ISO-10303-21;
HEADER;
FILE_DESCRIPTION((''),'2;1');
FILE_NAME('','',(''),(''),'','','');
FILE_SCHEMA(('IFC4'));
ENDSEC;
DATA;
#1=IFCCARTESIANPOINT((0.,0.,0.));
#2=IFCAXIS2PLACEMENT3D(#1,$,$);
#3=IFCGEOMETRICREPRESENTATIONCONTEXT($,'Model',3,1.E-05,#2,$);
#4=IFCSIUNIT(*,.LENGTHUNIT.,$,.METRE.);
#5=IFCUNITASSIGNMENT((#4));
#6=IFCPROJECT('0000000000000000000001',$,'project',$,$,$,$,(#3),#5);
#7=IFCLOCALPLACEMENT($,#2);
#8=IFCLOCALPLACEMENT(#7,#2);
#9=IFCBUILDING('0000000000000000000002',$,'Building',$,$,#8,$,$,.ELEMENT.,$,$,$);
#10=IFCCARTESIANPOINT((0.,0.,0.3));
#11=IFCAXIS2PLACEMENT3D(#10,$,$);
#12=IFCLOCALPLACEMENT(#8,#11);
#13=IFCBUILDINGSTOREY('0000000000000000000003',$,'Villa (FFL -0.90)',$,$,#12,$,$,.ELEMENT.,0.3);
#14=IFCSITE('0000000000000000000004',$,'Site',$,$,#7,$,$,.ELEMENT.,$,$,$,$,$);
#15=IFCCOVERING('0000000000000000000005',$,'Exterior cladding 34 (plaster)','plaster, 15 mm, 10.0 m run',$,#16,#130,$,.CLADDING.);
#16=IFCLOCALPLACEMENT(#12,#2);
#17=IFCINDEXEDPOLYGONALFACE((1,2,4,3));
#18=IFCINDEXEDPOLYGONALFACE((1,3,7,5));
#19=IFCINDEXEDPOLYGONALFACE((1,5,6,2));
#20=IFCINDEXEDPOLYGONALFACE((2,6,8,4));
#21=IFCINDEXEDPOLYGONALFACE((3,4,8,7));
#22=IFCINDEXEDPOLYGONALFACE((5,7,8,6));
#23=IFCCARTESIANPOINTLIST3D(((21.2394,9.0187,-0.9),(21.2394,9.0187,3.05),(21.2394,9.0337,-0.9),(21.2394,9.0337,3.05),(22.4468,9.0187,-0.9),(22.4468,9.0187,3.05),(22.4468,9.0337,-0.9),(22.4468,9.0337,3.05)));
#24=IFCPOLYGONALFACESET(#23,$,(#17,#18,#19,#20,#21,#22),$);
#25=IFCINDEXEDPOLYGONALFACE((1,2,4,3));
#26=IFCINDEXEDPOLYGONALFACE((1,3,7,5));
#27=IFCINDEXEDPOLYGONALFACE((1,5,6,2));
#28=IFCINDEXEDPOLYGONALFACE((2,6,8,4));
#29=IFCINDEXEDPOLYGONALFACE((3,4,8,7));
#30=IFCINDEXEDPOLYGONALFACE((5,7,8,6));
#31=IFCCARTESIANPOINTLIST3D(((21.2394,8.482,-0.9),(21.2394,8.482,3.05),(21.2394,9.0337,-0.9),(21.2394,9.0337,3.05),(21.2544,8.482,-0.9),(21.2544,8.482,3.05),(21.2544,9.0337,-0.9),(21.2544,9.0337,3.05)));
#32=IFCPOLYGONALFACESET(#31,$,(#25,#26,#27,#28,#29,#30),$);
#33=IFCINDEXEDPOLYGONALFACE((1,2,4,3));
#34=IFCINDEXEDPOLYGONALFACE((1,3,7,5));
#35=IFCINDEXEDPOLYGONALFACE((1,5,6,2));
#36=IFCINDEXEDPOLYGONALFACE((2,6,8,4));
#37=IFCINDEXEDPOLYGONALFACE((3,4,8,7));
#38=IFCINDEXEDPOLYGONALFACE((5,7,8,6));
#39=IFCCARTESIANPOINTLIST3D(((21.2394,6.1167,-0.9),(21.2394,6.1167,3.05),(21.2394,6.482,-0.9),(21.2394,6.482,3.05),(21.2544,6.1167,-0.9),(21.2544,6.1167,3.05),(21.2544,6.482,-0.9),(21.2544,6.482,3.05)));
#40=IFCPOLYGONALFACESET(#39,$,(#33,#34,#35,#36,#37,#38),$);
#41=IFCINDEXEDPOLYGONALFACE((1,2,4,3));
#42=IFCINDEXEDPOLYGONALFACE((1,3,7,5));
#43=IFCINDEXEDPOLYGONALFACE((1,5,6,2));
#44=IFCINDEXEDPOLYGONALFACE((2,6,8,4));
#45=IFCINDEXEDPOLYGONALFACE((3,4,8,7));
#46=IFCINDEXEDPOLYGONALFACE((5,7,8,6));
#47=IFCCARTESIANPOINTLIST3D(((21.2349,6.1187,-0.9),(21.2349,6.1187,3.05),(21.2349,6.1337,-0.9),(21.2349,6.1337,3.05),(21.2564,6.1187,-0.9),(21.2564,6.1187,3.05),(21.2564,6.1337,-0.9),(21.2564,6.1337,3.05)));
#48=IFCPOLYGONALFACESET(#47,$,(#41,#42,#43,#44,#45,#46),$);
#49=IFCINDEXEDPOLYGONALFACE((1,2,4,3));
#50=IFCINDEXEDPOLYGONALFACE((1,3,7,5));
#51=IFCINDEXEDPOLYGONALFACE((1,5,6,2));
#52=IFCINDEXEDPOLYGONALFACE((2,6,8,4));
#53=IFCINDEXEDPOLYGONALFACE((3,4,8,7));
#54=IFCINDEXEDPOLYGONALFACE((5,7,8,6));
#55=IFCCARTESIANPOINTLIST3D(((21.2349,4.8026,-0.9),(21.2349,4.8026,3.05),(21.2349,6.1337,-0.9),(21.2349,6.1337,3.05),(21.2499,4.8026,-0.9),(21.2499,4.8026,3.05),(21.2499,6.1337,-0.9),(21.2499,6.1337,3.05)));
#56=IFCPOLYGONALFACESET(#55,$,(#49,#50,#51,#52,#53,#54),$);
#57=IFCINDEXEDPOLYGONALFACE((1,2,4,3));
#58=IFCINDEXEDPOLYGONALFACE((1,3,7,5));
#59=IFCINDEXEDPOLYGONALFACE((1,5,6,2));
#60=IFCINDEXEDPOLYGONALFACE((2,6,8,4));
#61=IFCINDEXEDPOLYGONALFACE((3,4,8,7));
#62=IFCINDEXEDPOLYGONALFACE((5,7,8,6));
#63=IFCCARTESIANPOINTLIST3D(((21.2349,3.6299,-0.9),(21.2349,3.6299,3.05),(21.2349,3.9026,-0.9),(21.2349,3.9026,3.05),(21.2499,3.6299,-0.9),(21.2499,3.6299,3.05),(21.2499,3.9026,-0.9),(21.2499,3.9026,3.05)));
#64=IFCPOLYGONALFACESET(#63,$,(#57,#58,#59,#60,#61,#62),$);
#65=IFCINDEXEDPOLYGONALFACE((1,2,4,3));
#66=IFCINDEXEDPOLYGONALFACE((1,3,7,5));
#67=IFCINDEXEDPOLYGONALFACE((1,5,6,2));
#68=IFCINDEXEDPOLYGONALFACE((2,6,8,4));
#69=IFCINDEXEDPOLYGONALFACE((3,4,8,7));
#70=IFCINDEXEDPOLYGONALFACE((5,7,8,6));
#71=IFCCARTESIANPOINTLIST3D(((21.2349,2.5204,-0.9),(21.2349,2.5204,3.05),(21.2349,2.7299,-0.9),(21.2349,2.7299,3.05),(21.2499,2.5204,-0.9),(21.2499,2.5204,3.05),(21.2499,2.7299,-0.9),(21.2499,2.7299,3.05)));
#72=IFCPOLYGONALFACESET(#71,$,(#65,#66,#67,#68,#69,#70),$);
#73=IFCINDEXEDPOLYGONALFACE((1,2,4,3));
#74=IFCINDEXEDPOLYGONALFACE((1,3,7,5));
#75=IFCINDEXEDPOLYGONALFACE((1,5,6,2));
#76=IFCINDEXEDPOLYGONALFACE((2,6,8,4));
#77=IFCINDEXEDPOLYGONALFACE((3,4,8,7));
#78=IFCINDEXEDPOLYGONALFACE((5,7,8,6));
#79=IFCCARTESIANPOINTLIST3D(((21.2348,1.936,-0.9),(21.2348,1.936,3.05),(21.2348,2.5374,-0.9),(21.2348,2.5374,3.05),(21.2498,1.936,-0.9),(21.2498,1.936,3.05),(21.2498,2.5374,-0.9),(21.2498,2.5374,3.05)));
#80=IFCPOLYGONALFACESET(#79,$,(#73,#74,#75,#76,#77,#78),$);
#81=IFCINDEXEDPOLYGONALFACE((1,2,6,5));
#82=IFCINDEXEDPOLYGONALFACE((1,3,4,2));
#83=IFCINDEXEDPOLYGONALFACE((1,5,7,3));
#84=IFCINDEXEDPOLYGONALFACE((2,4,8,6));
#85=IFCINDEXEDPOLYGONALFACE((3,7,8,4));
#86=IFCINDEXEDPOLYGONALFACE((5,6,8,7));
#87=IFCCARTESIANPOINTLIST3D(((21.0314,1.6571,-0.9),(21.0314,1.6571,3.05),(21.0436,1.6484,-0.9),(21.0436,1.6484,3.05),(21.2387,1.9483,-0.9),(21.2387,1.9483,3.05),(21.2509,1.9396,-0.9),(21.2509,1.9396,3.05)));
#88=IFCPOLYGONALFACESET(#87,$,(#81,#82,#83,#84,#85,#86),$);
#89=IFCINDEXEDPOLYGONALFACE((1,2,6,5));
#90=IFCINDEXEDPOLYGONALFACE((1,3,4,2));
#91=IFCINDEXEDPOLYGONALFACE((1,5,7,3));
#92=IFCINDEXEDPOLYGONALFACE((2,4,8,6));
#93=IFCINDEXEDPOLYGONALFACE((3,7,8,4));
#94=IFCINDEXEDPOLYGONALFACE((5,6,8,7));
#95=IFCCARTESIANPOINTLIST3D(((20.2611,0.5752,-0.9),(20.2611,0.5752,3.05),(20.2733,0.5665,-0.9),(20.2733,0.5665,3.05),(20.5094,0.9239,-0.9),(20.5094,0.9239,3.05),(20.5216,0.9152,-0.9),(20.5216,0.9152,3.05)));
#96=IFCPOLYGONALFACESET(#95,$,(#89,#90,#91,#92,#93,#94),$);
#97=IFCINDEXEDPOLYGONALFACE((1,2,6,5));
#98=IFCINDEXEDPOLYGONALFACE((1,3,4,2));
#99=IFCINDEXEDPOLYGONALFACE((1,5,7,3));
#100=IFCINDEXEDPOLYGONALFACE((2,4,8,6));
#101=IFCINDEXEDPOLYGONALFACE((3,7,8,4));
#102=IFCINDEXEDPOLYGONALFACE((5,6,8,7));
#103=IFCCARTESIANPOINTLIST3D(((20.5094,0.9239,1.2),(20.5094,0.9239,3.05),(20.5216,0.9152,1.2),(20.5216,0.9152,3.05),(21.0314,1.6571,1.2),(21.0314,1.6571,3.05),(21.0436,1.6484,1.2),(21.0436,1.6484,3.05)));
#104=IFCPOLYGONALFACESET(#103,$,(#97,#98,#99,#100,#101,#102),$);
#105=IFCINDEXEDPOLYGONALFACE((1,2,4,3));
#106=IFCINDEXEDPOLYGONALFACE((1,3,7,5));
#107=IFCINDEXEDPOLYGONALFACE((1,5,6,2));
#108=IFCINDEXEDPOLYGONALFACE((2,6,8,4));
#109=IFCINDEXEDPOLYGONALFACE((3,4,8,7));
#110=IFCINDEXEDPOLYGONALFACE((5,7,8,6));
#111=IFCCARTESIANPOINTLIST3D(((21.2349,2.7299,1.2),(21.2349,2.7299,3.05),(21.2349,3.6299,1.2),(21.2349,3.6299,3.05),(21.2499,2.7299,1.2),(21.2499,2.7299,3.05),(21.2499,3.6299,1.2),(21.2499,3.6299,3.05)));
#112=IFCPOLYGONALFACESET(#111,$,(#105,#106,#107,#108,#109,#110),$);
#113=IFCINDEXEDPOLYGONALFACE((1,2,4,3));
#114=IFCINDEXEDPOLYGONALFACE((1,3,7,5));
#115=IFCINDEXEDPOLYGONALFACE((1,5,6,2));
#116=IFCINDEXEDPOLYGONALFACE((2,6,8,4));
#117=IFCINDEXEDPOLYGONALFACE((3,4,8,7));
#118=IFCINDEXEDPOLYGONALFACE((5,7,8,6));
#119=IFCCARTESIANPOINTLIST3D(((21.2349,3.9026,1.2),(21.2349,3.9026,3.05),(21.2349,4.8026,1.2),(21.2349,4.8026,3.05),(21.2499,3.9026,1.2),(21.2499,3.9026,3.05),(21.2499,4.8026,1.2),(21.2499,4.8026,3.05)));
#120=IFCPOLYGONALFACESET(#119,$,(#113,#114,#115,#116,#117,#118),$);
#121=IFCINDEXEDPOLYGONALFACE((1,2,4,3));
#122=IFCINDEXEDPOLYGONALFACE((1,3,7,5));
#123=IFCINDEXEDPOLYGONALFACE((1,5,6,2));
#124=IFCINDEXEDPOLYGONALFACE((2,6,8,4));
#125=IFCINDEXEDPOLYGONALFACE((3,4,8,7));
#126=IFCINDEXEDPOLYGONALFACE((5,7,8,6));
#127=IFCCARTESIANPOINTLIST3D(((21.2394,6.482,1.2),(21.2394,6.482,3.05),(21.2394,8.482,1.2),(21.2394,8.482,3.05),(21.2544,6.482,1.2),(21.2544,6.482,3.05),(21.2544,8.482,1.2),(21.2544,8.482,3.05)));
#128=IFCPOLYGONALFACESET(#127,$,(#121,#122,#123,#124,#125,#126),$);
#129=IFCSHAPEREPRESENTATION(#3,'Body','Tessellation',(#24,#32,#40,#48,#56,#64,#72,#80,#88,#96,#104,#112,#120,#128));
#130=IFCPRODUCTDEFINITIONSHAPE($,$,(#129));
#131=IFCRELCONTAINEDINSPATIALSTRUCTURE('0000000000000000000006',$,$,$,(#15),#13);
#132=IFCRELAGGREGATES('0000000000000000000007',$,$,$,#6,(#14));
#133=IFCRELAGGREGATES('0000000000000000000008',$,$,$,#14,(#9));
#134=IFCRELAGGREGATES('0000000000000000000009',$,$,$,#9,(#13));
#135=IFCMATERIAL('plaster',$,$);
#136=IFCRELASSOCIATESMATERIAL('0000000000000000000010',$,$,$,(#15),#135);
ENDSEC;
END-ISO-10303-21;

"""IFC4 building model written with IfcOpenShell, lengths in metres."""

from ifc_helpers import new_model, si_unit, frame, origin, origin_with_axes, place, context, project, spatial, polyline, outline, extrude, material, element, save


model = new_model("IFC4")

# Units and contexts
model_context = context("Model", 3, precision=1e-05, world=origin())
ifc_project = project(units=[si_unit("LENGTHUNIT", "METRE")], contexts=[model_context])

# Site, building, storey
site_placement = place(None, origin())
site = spatial("IfcSite", under=ifc_project, at=site_placement, Name="Site", CompositionType="ELEMENT")
building_placement = place(site_placement, origin())
building = spatial("IfcBuilding", under=site, at=building_placement, Name="Building", CompositionType="ELEMENT")
storey_placement = place(building_placement, frame((0.0, 0.0, 0.3)))
storey = spatial("IfcBuildingStorey", under=building, at=storey_placement, Name="Villa (FFL -0.90)", CompositionType="ELEMENT", Elevation=0.3)

# Covering
ifc_material = material(Name="plaster")
covering_1_placement = place(storey_placement, origin_with_axes())
element("IfcCovering", 1, at=covering_1_placement, inside=storey, material=ifc_material, Name="Exterior cladding 34 (plaster)", Description="plaster, 15 mm, 10.0 m run", PredefinedType="CLADDING", context=model_context, shape_type="SweptSolid", body=[
    extrude(outline(polyline([(22.4468, 9.0337), (21.2394, 9.0337), (21.2394, 9.0187), (22.4468, 9.0187), (22.4468, 9.0337)])), frame((0.0, 0.0, -0.9)), (0.0, 0.0, 1.0), 3.95),
    extrude(outline(polyline([(21.2394, 9.0337), (21.2394, 8.482), (21.2544, 8.482), (21.2544, 9.0337), (21.2394, 9.0337)])), frame((0.0, 0.0, -0.9)), (0.0, 0.0, 1.0), 3.95),
    extrude(outline(polyline([(21.2394, 6.482), (21.2394, 6.1167), (21.2544, 6.1167), (21.2544, 6.482), (21.2394, 6.482)])), frame((0.0, 0.0, -0.9)), (0.0, 0.0, 1.0), 3.95),
    extrude(outline(polyline([(21.2564, 6.1337), (21.2349, 6.1337), (21.2349, 6.1187), (21.2564, 6.1187), (21.2564, 6.1337)])), frame((0.0, 0.0, -0.9)), (0.0, 0.0, 1.0), 3.95),
    extrude(outline(polyline([(21.2349, 6.1337), (21.2349, 4.8026), (21.2499, 4.8026), (21.2499, 6.1337), (21.2349, 6.1337)])), frame((0.0, 0.0, -0.9)), (0.0, 0.0, 1.0), 3.95),
    extrude(outline(polyline([(21.2349, 3.9026), (21.2349, 3.6299), (21.2499, 3.6299), (21.2499, 3.9026), (21.2349, 3.9026)])), frame((0.0, 0.0, -0.9)), (0.0, 0.0, 1.0), 3.95),
    extrude(outline(polyline([(21.2349, 2.7299), (21.2349, 2.5204), (21.2499, 2.5204), (21.2499, 2.7299), (21.2349, 2.7299)])), frame((0.0, 0.0, -0.9)), (0.0, 0.0, 1.0), 3.95),
    extrude(outline(polyline([(21.2348, 2.5374), (21.2348, 1.936), (21.2498, 1.936), (21.2498, 2.5374), (21.2348, 2.5374)])), frame((0.0, 0.0, -0.9)), (0.0, 0.0, 1.0), 3.95),
    extrude(outline(polyline([(21.2387, 1.9483), (21.0314, 1.6571), (21.0436, 1.6484), (21.2509, 1.9396), (21.2387, 1.9483)])), frame((0.0, 0.0, -0.9)), (0.0, 0.0, 1.0), 3.95),
    extrude(outline(polyline([(20.5094, 0.9239), (20.2611, 0.5752), (20.2733, 0.5665), (20.5216, 0.9152), (20.5094, 0.9239)])), frame((0.0, 0.0, -0.9)), (0.0, 0.0, 1.0), 3.95),
    extrude(outline(polyline([(21.0314, 1.6571), (20.5094, 0.9239), (20.5216, 0.9152), (21.0436, 1.6484), (21.0314, 1.6571)])), frame((0.0, 0.0, 1.2)), (0.0, 0.0, 1.0), 1.85),
    extrude(outline(polyline([(21.2349, 3.6299), (21.2349, 2.7299), (21.2499, 2.7299), (21.2499, 3.6299), (21.2349, 3.6299)])), frame((0.0, 0.0, 1.2)), (0.0, 0.0, 1.0), 1.85),
    extrude(outline(polyline([(21.2349, 4.8026), (21.2349, 3.9026), (21.2499, 3.9026), (21.2499, 4.8026), (21.2349, 4.8026)])), frame((0.0, 0.0, 1.2)), (0.0, 0.0, 1.0), 1.85),
    extrude(outline(polyline([(21.2394, 8.482), (21.2394, 6.482), (21.2544, 6.482), (21.2544, 8.482), (21.2394, 8.482)])), frame((0.0, 0.0, 1.2)), (0.0, 0.0, 1.0), 1.85),
])

save(model, "model.ifc")
